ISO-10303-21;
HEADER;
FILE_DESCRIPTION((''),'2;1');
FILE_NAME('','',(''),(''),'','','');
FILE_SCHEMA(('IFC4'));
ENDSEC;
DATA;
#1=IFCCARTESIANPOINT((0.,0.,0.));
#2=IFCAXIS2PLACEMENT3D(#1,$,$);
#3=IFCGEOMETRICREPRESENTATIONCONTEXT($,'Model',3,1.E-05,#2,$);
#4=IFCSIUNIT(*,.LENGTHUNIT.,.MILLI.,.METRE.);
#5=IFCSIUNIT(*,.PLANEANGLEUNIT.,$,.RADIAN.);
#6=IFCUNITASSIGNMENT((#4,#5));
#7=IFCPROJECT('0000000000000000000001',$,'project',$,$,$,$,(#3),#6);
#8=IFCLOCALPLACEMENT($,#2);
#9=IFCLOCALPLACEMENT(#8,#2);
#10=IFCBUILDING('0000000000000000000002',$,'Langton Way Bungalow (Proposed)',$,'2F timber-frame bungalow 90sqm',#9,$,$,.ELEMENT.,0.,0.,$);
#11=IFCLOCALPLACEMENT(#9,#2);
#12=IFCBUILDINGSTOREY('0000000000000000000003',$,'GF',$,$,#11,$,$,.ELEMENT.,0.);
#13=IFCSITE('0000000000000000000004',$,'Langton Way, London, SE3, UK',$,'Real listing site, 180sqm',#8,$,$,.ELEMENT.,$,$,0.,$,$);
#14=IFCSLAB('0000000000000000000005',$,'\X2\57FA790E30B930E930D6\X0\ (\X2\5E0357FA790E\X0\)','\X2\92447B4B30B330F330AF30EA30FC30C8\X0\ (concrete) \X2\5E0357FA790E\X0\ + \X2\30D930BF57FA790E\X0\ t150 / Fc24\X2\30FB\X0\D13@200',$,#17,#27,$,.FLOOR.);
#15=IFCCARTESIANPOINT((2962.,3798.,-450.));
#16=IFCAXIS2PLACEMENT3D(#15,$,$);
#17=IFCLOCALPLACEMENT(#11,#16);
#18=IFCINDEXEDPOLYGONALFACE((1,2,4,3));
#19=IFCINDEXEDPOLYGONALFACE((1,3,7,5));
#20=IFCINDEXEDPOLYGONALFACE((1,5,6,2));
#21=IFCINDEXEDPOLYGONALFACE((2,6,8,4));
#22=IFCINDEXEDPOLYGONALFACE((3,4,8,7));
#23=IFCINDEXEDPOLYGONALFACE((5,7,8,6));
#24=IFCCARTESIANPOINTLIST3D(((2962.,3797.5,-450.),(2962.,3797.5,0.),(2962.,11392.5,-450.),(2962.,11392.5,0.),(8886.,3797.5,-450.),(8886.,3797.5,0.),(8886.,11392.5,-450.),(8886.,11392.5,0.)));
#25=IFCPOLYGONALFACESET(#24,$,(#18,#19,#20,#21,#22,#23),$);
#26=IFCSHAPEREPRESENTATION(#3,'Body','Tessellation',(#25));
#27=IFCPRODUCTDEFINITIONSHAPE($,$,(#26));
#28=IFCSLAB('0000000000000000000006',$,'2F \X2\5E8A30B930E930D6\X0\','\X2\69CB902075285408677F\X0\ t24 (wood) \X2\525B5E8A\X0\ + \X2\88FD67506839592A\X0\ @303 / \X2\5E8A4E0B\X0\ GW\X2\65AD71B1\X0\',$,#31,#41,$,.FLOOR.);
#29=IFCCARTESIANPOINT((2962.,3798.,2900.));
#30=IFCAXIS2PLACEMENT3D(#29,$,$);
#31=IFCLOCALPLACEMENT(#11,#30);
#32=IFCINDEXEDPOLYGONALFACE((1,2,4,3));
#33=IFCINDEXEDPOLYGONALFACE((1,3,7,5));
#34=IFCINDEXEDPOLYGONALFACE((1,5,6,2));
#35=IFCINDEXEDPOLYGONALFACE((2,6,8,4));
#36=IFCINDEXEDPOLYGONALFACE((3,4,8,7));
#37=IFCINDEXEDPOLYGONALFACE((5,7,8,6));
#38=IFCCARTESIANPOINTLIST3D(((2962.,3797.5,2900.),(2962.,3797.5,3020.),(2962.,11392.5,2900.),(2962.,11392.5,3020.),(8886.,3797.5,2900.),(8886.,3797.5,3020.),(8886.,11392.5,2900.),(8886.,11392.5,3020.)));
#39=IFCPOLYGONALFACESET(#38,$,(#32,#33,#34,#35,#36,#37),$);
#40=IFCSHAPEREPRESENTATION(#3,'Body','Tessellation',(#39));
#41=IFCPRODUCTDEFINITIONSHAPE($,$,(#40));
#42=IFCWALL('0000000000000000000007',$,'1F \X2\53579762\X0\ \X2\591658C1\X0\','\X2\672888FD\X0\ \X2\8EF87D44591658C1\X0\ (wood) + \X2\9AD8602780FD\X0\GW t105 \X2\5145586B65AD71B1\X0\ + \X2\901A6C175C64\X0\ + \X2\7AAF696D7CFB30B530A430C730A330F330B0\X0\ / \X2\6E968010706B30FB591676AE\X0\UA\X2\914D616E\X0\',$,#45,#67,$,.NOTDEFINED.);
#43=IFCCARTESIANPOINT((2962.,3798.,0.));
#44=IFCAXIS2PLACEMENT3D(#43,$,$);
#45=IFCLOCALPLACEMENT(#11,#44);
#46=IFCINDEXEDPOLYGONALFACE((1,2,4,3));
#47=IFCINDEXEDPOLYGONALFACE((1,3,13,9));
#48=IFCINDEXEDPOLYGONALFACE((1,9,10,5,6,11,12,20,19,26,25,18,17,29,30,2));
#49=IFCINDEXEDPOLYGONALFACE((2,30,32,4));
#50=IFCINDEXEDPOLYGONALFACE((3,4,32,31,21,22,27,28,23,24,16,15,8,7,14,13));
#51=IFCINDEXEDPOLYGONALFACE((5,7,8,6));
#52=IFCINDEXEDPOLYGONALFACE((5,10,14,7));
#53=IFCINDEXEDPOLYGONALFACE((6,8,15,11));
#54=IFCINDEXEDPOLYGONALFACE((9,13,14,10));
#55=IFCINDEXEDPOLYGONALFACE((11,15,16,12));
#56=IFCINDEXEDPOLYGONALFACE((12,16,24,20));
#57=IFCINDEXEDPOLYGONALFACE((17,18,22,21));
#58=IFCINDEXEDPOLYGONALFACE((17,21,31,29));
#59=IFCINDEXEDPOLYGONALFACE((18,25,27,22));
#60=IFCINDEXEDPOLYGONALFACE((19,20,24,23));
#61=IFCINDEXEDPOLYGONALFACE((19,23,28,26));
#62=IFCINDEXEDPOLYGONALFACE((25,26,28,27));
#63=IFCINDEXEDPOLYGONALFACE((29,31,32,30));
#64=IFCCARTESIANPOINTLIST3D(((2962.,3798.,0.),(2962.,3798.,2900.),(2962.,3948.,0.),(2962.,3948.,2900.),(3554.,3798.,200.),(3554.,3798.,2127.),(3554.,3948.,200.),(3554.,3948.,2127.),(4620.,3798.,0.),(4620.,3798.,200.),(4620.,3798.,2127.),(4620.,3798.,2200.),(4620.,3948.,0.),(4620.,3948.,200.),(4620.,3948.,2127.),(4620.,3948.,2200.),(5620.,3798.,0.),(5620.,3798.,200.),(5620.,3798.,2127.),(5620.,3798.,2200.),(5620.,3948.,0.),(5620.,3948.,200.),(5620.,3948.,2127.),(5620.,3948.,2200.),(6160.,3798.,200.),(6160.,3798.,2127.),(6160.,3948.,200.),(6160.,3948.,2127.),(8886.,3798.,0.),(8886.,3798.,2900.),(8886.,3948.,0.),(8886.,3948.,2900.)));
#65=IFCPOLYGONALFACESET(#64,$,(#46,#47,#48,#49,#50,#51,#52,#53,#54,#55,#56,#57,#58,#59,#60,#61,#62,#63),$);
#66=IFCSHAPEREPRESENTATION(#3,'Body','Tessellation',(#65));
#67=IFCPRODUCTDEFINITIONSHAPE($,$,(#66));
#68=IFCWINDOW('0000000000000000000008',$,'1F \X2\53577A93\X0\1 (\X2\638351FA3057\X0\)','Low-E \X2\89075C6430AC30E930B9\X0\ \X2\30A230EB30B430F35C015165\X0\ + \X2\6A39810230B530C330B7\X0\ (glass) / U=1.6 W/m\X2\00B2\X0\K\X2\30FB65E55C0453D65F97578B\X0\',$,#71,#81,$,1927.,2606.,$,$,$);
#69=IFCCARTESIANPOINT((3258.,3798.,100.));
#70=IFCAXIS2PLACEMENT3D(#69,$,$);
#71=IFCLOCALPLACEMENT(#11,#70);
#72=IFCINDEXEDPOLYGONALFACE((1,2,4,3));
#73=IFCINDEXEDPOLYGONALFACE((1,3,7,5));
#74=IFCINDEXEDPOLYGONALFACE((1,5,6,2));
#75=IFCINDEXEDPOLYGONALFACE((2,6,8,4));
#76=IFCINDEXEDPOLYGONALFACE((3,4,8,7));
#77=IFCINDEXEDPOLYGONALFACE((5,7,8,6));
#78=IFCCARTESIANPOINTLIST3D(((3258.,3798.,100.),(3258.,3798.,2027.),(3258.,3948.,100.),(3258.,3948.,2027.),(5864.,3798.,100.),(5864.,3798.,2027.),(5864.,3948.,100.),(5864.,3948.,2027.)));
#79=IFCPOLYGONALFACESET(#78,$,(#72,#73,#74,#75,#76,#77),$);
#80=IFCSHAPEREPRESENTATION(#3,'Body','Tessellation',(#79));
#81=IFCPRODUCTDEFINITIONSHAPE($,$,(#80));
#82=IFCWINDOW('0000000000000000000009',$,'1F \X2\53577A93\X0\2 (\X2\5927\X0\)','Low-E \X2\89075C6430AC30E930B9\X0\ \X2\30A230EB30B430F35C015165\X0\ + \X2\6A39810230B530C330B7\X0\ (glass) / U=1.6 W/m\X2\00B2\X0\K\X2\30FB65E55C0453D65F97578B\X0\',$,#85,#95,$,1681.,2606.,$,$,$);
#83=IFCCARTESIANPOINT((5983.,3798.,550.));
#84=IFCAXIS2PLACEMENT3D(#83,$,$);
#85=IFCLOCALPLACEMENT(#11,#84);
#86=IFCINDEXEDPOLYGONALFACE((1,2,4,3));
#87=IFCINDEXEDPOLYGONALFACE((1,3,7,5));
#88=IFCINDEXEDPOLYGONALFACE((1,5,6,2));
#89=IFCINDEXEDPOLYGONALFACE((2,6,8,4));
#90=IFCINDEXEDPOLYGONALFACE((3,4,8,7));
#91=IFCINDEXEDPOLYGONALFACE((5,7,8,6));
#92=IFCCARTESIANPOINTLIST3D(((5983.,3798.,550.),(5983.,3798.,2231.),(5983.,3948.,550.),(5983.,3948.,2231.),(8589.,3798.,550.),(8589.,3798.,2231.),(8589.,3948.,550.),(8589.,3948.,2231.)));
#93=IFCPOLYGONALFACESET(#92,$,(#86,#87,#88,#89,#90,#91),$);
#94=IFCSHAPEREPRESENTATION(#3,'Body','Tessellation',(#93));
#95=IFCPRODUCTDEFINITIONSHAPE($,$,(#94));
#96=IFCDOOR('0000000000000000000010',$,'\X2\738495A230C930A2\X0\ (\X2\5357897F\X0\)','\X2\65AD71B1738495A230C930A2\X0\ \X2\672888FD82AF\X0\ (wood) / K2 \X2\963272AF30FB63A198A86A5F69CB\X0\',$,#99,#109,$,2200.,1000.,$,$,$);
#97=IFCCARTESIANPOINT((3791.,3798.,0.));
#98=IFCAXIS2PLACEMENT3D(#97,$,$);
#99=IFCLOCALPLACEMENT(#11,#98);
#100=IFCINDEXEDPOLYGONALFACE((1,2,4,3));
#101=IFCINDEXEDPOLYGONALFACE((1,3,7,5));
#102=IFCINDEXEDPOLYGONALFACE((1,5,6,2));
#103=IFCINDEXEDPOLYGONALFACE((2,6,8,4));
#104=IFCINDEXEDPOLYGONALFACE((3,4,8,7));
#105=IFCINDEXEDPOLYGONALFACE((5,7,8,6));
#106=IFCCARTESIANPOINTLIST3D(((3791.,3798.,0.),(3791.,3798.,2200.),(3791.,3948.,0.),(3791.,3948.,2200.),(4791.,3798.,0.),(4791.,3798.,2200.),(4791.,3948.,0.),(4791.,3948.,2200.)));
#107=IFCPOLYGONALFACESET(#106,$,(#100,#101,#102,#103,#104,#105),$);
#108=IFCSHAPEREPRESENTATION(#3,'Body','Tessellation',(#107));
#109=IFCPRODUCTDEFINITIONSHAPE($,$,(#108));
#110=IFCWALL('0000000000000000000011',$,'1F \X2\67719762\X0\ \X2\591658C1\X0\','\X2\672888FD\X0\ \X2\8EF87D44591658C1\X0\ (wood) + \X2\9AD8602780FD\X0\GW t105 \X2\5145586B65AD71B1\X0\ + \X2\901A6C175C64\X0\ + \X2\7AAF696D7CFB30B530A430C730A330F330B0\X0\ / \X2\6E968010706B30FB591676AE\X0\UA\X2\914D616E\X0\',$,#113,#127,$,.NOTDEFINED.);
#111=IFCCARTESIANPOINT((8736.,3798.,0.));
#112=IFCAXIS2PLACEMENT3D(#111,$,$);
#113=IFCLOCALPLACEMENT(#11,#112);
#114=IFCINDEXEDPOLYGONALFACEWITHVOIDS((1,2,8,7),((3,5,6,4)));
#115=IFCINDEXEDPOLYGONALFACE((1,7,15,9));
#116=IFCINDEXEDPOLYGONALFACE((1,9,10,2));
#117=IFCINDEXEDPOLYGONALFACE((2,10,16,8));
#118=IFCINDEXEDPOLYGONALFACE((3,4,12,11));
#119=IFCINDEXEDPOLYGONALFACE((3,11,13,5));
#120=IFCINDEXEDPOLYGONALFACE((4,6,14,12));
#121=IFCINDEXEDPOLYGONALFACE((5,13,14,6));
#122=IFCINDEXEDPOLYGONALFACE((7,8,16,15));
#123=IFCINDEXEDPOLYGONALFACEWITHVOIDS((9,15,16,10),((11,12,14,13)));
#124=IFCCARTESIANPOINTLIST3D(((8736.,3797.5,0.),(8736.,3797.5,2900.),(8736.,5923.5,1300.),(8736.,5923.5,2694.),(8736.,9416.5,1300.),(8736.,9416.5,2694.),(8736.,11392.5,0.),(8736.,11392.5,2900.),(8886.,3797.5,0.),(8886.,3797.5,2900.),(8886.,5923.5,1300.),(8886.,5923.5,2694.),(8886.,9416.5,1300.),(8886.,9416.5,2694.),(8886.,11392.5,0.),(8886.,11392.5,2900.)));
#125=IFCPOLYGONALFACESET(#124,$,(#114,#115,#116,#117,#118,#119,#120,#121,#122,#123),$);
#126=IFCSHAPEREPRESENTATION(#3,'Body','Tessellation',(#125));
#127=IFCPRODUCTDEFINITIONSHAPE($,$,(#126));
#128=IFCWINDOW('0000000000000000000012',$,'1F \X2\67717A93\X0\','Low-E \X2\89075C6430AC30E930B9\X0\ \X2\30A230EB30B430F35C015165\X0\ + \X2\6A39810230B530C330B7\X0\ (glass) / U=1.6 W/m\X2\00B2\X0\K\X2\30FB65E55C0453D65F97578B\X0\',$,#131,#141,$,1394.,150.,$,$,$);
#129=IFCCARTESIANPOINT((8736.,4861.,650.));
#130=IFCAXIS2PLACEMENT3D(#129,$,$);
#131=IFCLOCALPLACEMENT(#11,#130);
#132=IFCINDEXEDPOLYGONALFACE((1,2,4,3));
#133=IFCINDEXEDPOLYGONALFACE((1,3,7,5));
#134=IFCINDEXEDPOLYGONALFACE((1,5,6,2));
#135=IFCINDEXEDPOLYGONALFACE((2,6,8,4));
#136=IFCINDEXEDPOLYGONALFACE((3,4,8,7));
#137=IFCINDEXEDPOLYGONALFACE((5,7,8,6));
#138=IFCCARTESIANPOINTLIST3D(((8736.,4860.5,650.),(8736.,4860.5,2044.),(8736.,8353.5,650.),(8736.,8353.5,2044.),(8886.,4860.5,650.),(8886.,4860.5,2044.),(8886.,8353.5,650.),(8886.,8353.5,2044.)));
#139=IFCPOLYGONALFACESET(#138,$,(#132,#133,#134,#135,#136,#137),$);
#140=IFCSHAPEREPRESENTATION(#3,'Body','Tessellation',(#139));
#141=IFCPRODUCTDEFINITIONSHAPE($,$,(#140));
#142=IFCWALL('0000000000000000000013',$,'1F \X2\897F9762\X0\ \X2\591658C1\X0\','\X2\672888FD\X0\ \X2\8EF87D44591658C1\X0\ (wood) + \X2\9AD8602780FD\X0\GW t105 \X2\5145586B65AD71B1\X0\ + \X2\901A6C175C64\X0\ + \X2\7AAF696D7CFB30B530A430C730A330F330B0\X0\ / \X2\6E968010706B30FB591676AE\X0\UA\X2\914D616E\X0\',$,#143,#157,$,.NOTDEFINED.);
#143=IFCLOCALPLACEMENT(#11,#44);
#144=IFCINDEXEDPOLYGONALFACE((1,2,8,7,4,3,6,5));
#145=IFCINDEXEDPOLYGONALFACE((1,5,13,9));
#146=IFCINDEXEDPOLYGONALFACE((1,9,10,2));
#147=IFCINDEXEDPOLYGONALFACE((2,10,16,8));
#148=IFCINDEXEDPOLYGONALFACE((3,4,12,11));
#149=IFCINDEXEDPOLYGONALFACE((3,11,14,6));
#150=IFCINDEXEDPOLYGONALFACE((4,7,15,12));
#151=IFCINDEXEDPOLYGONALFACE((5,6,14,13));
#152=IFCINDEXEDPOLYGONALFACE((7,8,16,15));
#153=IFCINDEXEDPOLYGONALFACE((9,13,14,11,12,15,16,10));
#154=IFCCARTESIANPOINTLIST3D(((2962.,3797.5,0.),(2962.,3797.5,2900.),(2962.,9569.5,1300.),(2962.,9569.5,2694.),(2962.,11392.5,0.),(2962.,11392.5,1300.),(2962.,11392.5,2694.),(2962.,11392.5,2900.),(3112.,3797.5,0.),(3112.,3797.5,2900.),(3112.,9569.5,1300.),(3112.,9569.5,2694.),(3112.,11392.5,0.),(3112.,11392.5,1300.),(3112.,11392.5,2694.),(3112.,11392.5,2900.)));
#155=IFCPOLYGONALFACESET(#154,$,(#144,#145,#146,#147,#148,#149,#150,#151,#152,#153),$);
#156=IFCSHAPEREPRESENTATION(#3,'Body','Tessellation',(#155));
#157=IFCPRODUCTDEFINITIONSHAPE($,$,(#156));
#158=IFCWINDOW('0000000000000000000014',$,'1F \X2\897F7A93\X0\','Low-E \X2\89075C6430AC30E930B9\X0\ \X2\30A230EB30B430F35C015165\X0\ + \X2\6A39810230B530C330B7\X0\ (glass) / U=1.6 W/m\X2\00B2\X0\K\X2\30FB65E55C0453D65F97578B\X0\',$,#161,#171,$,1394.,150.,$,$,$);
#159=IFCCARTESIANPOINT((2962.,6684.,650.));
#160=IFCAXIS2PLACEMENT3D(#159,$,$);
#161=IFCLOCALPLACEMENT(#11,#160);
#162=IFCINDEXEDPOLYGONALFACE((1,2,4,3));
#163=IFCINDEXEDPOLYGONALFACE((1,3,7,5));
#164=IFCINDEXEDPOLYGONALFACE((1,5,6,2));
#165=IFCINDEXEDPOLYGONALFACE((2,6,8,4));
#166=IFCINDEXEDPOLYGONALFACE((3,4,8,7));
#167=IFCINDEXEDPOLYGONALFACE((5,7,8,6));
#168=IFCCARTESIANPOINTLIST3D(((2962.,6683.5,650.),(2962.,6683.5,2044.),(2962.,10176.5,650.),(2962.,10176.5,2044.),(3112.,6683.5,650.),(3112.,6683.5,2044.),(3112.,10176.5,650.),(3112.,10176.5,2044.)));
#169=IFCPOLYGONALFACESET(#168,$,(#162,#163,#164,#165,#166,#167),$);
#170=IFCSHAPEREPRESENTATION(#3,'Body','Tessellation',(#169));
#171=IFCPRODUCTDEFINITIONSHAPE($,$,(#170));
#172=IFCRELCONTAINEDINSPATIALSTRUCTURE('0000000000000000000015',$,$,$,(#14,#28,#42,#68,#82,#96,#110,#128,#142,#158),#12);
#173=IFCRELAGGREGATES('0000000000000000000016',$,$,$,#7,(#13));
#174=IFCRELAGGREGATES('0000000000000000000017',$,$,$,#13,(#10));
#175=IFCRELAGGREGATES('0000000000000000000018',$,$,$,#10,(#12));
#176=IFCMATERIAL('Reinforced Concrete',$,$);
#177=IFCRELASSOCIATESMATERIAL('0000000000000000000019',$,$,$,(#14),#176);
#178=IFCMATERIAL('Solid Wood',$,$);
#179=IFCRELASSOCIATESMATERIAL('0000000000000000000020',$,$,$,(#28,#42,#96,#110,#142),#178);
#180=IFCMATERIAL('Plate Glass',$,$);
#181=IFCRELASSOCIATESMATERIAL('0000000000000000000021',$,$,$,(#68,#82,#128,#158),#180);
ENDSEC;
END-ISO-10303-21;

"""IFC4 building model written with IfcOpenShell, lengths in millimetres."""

from ifc_helpers import new_model, si_unit, frame, frame_2d, origin, place, context, project, spatial, rectangle, extrude, material, element, fill, save


model = new_model("IFC4")

# Units and contexts
model_context = context("Model", 3, precision=1e-05, world=origin())
ifc_project = project(units=[si_unit("LENGTHUNIT", "METRE", prefix="MILLI"), si_unit("PLANEANGLEUNIT", "RADIAN")], contexts=[model_context])

# Site, building, storey
site_placement = place(None, origin())
site = spatial("IfcSite", under=ifc_project, at=site_placement, Name="Langton Way, London, SE3, UK", ObjectType="Real listing site, 180sqm", CompositionType="ELEMENT", RefElevation=0.0)
building_placement = place(site_placement, origin())
building = spatial("IfcBuilding", under=site, at=building_placement, Name="Langton Way Bungalow (Proposed)", ObjectType="2F timber-frame bungalow 90sqm", CompositionType="ELEMENT", ElevationOfRefHeight=0.0, ElevationOfTerrain=0.0)
storey_placement = place(building_placement, origin())
storey = spatial("IfcBuildingStorey", under=building, at=storey_placement, Name="GF", CompositionType="ELEMENT", Elevation=0.0)

# Slabs
ifc_material_1 = material(Name="Reinforced Concrete")
slab_1_placement = place(storey_placement, frame((2962.0, 3798.0, -450.0)))
element("IfcSlab", 1, at=slab_1_placement, inside=storey, material=ifc_material_1, Name="基礎スラブ (布基礎)", Description="鉄筋コンクリート (concrete) 布基礎 + ベタ基礎 t150 / Fc24・D13@200", PredefinedType="FLOOR", context=model_context, shape_type="SweptSolid", body=[
    extrude(rectangle(XDim=5924.0, YDim=7595.0, at=frame_2d((2962.0, 3797.0))), frame((2962.0, 3798.0, -450.0)), (0.0, 0.0, 1.0), 450.0),
])
ifc_material_2 = material(Name="Solid Wood")
slab_2_placement = place(storey_placement, frame((2962.0, 3798.0, 2900.0)))
element("IfcSlab", 2, at=slab_2_placement, inside=storey, material=ifc_material_2, Name="2F 床スラブ", Description="構造用合板 t24 (wood) 剛床 + 製材根太 @303 / 床下 GW断熱", PredefinedType="FLOOR", context=model_context, shape_type="SweptSolid", body=[
    extrude(rectangle(XDim=5924.0, YDim=7595.0, at=frame_2d((2962.0, 3797.0))), frame((2962.0, 3798.0, 2900.0)), (0.0, 0.0, 1.0), 120.0),
])

# Wall, openings, windows, door
wall_1_placement = place(storey_placement, frame((2962.0, 3798.0, 0.0)))
wall_1 = element("IfcWall", 3, at=wall_1_placement, inside=storey, material=ifc_material_2, Name="1F 南面 外壁", Description="木製 軸組外壁 (wood) + 高性能GW t105 充填断熱 + 通気層 + 窯業系サイディング / 準耐火・外皮UA配慮", PredefinedType="NOTDEFINED", context=model_context, shape_type="SweptSolid", body=[
    extrude(rectangle(XDim=5924.0, YDim=150.0, at=frame_2d((2962.0, 75.0))), frame((2962.0, 3798.0, 0.0)), (0.0, 0.0, 1.0), 2900.0),
])
opening_1_placement = place(storey_placement, frame((3258.0, 3798.0, 100.0)))
opening_1 = element("IfcOpeningElement", 4, at=opening_1_placement, cuts=wall_1, PredefinedType="NOTDEFINED", context=model_context, shape_type="SweptSolid", body=[
    extrude(rectangle(XDim=2606.0, YDim=150.0, at=frame_2d((1303.0, 75.0))), frame((3258.0, 3798.0, 100.0)), (0.0, 0.0, 1.0), 1927.0),
])
opening_2_placement = place(storey_placement, frame((5983.0, 3798.0, 550.0)))
opening_2 = element("IfcOpeningElement", 5, at=opening_2_placement, cuts=wall_1, PredefinedType="NOTDEFINED", context=model_context, shape_type="SweptSolid", body=[
    extrude(rectangle(XDim=2606.0, YDim=150.0, at=frame_2d((1303.0, 75.0))), frame((5983.0, 3798.0, 550.0)), (0.0, 0.0, 1.0), 1681.0),
])
opening_3_placement = place(storey_placement, frame((3791.0, 3798.0, 0.0)))
opening_3 = element("IfcOpeningElement", 6, at=opening_3_placement, cuts=wall_1, PredefinedType="NOTDEFINED", context=model_context, shape_type="SweptSolid", body=[
    extrude(rectangle(XDim=1000.0, YDim=150.0, at=frame_2d((500.0, 75.0))), frame((3791.0, 3798.0, 0.0)), (0.0, 0.0, 1.0), 2200.0),
])
ifc_material_3 = material(Name="Plate Glass")
window_1_placement = place(storey_placement, frame((3258.0, 3798.0, 100.0)))
window_1 = element("IfcWindow", 7, at=window_1_placement, inside=storey, material=ifc_material_3, Name="1F 南窓1 (掃出し)", Description="Low-E 複層ガラス アルゴン封入 + 樹脂サッシ (glass) / U=1.6 W/m²K・日射取得型", OverallHeight=1927.0, OverallWidth=2606.0, context=model_context, shape_type="SweptSolid", body=[
    extrude(rectangle(XDim=2606.0, YDim=150.0, at=frame_2d((1303.0, 75.0))), frame((3258.0, 3798.0, 100.0)), (0.0, 0.0, 1.0), 1927.0),
])
fill(opening_1, window_1)
window_2_placement = place(storey_placement, frame((5983.0, 3798.0, 550.0)))
window_2 = element("IfcWindow", 8, at=window_2_placement, inside=storey, material=ifc_material_3, Name="1F 南窓2 (大)", Description="Low-E 複層ガラス アルゴン封入 + 樹脂サッシ (glass) / U=1.6 W/m²K・日射取得型", OverallHeight=1681.0, OverallWidth=2606.0, context=model_context, shape_type="SweptSolid", body=[
    extrude(rectangle(XDim=2606.0, YDim=150.0, at=frame_2d((1303.0, 75.0))), frame((5983.0, 3798.0, 550.0)), (0.0, 0.0, 1.0), 1681.0),
])
fill(opening_2, window_2)
door_placement = place(storey_placement, frame((3791.0, 3798.0, 0.0)))
door = element("IfcDoor", 9, at=door_placement, inside=storey, material=ifc_material_2, Name="玄関ドア (南西)", Description="断熱玄関ドア 木製芯 (wood) / K2 防犯・採風機構", OverallHeight=2200.0, OverallWidth=1000.0, context=model_context, shape_type="SweptSolid", body=[
    extrude(rectangle(XDim=1000.0, YDim=150.0, at=frame_2d((500.0, 75.0))), frame((3791.0, 3798.0, 0.0)), (0.0, 0.0, 1.0), 2200.0),
])
fill(opening_3, door)

# Walls, openings, windows
wall_2_placement = place(storey_placement, frame((8736.0, 3798.0, 0.0)))
wall_2 = element("IfcWall", 10, at=wall_2_placement, inside=storey, material=ifc_material_2, Name="1F 東面 外壁", Description="木製 軸組外壁 (wood) + 高性能GW t105 充填断熱 + 通気層 + 窯業系サイディング / 準耐火・外皮UA配慮", PredefinedType="NOTDEFINED", context=model_context, shape_type="SweptSolid", body=[
    extrude(rectangle(XDim=150.0, YDim=7595.0, at=frame_2d((75.0, 3797.0))), frame((8736.0, 3798.0, 0.0)), (0.0, 0.0, 1.0), 2900.0),
])
opening_4_placement = place(storey_placement, frame((8736.0, 4861.0, 650.0)))
opening_4 = element("IfcOpeningElement", 11, at=opening_4_placement, cuts=wall_2, PredefinedType="NOTDEFINED", context=model_context, shape_type="SweptSolid", body=[
    extrude(rectangle(XDim=150.0, YDim=3493.0, at=frame_2d((75.0, 1746.0))), frame((8736.0, 4861.0, 650.0)), (0.0, 0.0, 1.0), 1394.0),
])
window_3_placement = place(storey_placement, frame((8736.0, 4861.0, 650.0)))
window_3 = element("IfcWindow", 12, at=window_3_placement, inside=storey, material=ifc_material_3, Name="1F 東窓", Description="Low-E 複層ガラス アルゴン封入 + 樹脂サッシ (glass) / U=1.6 W/m²K・日射取得型", OverallHeight=1394.0, OverallWidth=150.0, context=model_context, shape_type="SweptSolid", body=[
    extrude(rectangle(XDim=150.0, YDim=3493.0, at=frame_2d((75.0, 1746.0))), frame((8736.0, 4861.0, 650.0)), (0.0, 0.0, 1.0), 1394.0),
])
fill(opening_4, window_3)
wall_3_placement = place(storey_placement, frame((2962.0, 3798.0, 0.0)))
wall_3 = element("IfcWall", 13, at=wall_3_placement, inside=storey, material=ifc_material_2, Name="1F 西面 外壁", Description="木製 軸組外壁 (wood) + 高性能GW t105 充填断熱 + 通気層 + 窯業系サイディング / 準耐火・外皮UA配慮", PredefinedType="NOTDEFINED", context=model_context, shape_type="SweptSolid", body=[
    extrude(rectangle(XDim=150.0, YDim=7595.0, at=frame_2d((75.0, 3797.0))), frame((2962.0, 3798.0, 0.0)), (0.0, 0.0, 1.0), 2900.0),
])
opening_5_placement = place(storey_placement, frame((2962.0, 6684.0, 650.0)))
opening_5 = element("IfcOpeningElement", 14, at=opening_5_placement, cuts=wall_3, PredefinedType="NOTDEFINED", context=model_context, shape_type="SweptSolid", body=[
    extrude(rectangle(XDim=150.0, YDim=3493.0, at=frame_2d((75.0, 1746.0))), frame((2962.0, 6684.0, 650.0)), (0.0, 0.0, 1.0), 1394.0),
])
window_4_placement = place(storey_placement, frame((2962.0, 6684.0, 650.0)))
window_4 = element("IfcWindow", 15, at=window_4_placement, inside=storey, material=ifc_material_3, Name="1F 西窓", Description="Low-E 複層ガラス アルゴン封入 + 樹脂サッシ (glass) / U=1.6 W/m²K・日射取得型", OverallHeight=1394.0, OverallWidth=150.0, context=model_context, shape_type="SweptSolid", body=[
    extrude(rectangle(XDim=150.0, YDim=3493.0, at=frame_2d((75.0, 1746.0))), frame((2962.0, 6684.0, 650.0)), (0.0, 0.0, 1.0), 1394.0),
])
fill(opening_5, window_4)

save(model, "model.ifc")
